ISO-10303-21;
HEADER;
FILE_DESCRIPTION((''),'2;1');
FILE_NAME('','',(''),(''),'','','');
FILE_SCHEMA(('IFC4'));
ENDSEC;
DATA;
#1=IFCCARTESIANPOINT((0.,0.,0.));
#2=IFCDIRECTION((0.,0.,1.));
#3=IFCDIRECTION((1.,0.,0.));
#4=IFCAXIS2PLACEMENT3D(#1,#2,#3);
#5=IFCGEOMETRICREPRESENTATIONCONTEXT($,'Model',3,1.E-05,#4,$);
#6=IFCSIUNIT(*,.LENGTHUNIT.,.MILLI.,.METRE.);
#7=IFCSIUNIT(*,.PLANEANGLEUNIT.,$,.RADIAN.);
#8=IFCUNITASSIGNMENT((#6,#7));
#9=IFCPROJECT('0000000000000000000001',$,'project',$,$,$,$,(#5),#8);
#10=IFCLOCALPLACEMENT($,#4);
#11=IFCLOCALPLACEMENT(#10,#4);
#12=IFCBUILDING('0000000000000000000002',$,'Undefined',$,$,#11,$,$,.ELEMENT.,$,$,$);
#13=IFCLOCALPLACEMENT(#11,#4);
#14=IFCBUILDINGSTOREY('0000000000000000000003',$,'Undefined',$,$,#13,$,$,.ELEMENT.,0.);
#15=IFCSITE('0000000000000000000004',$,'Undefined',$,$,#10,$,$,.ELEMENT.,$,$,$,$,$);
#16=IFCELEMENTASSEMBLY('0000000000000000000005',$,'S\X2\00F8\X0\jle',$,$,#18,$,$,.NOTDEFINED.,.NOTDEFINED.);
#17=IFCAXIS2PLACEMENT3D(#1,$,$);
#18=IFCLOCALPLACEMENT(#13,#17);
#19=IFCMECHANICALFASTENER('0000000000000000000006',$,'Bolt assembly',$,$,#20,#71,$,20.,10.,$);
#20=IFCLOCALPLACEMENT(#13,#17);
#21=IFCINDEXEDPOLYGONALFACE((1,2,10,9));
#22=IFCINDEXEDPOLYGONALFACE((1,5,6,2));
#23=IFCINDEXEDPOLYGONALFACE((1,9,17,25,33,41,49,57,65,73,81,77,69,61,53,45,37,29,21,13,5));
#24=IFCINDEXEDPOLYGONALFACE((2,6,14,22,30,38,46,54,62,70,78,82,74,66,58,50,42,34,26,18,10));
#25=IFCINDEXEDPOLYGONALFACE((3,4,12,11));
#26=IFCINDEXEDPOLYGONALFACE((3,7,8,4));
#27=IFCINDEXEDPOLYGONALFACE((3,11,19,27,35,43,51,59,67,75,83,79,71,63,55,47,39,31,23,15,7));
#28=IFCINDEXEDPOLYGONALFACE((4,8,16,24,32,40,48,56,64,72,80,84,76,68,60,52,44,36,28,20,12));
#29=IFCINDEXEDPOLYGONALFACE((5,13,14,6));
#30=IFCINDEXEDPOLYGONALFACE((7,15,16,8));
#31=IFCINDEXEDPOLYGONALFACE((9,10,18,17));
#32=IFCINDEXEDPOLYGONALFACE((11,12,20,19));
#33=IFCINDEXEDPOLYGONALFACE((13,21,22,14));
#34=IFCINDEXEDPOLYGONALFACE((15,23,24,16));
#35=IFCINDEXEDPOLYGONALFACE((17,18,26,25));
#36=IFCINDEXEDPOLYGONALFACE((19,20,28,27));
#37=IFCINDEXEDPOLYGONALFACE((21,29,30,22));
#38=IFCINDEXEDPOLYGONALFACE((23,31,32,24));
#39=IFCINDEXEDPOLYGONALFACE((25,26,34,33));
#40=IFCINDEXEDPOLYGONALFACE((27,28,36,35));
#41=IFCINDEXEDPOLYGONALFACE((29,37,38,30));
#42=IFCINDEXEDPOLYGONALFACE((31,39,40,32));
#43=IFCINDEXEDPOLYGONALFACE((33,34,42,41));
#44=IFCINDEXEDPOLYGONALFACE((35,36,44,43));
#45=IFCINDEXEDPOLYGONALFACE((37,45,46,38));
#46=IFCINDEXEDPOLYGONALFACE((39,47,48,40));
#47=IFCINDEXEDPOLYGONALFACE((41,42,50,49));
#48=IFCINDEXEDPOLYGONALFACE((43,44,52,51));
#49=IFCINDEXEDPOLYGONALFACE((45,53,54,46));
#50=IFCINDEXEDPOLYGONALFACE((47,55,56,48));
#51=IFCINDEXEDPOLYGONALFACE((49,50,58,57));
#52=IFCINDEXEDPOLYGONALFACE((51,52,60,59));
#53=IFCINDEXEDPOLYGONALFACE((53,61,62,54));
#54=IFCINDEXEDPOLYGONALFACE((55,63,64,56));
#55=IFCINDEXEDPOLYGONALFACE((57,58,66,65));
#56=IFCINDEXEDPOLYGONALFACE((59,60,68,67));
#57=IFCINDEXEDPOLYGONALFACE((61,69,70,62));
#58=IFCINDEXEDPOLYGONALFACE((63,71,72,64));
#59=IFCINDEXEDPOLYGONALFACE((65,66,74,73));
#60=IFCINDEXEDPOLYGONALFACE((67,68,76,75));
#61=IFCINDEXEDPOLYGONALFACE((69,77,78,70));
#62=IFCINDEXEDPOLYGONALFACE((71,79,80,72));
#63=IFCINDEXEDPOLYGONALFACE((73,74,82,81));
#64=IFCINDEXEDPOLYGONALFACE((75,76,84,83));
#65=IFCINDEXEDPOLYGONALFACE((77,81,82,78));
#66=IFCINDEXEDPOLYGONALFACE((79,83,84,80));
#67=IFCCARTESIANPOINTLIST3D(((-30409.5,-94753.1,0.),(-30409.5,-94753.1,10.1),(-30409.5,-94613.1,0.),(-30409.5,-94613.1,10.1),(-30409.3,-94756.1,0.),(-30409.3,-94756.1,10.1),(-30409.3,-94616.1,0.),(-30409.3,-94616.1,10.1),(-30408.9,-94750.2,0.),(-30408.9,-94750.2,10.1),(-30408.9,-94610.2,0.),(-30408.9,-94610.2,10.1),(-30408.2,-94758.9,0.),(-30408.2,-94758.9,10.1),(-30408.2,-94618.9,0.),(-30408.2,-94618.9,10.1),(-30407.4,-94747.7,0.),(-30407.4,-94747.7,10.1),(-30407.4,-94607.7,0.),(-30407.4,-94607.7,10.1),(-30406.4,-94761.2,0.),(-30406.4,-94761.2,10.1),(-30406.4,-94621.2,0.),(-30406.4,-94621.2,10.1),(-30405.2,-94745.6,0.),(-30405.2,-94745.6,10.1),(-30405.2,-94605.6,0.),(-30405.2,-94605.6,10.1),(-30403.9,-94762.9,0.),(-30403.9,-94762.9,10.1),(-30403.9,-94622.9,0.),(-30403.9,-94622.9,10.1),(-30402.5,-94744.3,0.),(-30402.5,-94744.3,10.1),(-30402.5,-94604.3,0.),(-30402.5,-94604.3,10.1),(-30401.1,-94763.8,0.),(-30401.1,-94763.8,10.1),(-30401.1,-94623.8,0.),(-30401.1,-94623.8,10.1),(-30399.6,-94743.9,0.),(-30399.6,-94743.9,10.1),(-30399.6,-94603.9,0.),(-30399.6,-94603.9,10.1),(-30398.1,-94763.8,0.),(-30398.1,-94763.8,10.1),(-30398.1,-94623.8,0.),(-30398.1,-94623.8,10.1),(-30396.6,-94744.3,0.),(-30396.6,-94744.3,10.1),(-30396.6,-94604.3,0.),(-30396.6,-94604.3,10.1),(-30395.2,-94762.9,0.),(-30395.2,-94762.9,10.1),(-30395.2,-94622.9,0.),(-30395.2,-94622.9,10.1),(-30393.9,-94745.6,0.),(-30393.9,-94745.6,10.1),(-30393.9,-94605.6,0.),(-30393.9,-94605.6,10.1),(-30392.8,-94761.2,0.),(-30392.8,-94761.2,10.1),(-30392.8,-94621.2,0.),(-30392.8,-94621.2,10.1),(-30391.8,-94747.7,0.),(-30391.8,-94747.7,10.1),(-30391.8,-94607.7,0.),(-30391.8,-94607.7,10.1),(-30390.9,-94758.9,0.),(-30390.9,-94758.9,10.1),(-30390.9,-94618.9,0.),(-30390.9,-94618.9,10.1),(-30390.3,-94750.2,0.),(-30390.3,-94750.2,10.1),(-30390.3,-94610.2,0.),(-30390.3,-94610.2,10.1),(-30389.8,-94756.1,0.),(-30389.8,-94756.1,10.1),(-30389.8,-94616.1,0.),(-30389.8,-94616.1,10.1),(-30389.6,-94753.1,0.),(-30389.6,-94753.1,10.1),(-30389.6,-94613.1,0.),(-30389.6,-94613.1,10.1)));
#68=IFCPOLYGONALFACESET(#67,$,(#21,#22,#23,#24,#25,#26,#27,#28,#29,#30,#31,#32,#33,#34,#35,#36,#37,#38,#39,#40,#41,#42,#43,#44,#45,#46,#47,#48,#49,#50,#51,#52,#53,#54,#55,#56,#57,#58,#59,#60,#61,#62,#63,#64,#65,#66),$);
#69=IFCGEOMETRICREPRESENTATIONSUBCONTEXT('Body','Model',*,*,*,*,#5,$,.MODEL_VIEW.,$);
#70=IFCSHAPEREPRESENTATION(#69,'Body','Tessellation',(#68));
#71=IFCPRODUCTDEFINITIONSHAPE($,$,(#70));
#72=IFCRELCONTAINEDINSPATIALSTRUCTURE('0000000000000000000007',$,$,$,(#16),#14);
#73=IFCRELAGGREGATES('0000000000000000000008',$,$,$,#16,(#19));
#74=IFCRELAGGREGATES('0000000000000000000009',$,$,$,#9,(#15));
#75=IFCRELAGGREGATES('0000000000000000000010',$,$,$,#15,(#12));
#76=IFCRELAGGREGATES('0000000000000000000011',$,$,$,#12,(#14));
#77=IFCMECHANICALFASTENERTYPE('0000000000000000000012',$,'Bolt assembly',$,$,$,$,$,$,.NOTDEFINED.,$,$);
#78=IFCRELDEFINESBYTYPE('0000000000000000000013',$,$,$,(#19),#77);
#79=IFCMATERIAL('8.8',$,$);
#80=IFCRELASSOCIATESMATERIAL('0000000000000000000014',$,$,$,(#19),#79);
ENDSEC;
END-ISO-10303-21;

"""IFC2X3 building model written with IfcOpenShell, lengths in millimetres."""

from ifc_helpers import new_model, si_unit, frame, origin_with_axes, origin_2d_with_axis, place, context, subcontext, project, spatial, circle, extrude, source, transform, mapped, material, type_object, element, aggregate, save


model = new_model("IFC2X3")

# Units and contexts
model_context = context("Model", 3, precision=1e-05, world=origin_with_axes())
body_context = subcontext(model_context, "Body", "Model", "MODEL_VIEW")
ifc_project = project(units=[si_unit("LENGTHUNIT", "METRE", prefix="MILLI"), si_unit("PLANEANGLEUNIT", "RADIAN")], contexts=[model_context])

# Site, building, storey
site_placement = place(None, origin_with_axes())
site = spatial("IfcSite", under=ifc_project, at=site_placement, Name="Undefined", CompositionType="ELEMENT")
building_placement = place(site_placement, origin_with_axes())
building = spatial("IfcBuilding", under=site, at=building_placement, Name="Undefined", CompositionType="ELEMENT")
storey_placement = place(building_placement, origin_with_axes())
storey = spatial("IfcBuildingStorey", under=building, at=storey_placement, Name="Undefined", CompositionType="ELEMENT", Elevation=0.0)

# Element assembly
assembly_1_placement = place(storey_placement, origin_with_axes())
assembly_1 = element("IfcElementAssembly", 1, at=assembly_1_placement, inside=storey, Name="Søjle", AssemblyPlace="NOTDEFINED", PredefinedType="NOTDEFINED")

# Mechanical fastener
ifc_material_1 = material(Name="8.8")
mechanical_fastener_type = type_object("IfcMechanicalFastenerType", Name="Bolt assembly")
shared_shape_1 = source(origin_with_axes(), body_context, "Body", "SweptSolid", [
    extrude(circle(Radius=10.0, at=origin_2d_with_axis()), frame((0.0, -10.0, 0.0), z_axis=(0.0, 1.0, 0.0), x_axis=(1.0, 0.0, 0.0)), (0.0, 0.0, 1.0), 10.1),
])
mechanical_fastener_1_placement = place(assembly_1_placement, frame((-30399.6, -94753.9, 10.0), z_axis=(1.0, 0.0, 0.0), x_axis=(0.0, 1.0, 0.0)))
mechanical_fastener_1 = element("IfcMechanicalFastener", 2, at=mechanical_fastener_1_placement, type_object=mechanical_fastener_type, material=ifc_material_1, Name="Bolt assembly", NominalDiameter=20.0, NominalLength=10.0, context=body_context, shape_type="MappedRepresentation", body=[
    mapped(shared_shape_1, transform((0.0, 0.0, 0.0))),
    mapped(shared_shape_1, transform((140.0, 0.0, 0.0))),
])
aggregate(assembly_1, [mechanical_fastener_1])

save(model, "model.ifc")
